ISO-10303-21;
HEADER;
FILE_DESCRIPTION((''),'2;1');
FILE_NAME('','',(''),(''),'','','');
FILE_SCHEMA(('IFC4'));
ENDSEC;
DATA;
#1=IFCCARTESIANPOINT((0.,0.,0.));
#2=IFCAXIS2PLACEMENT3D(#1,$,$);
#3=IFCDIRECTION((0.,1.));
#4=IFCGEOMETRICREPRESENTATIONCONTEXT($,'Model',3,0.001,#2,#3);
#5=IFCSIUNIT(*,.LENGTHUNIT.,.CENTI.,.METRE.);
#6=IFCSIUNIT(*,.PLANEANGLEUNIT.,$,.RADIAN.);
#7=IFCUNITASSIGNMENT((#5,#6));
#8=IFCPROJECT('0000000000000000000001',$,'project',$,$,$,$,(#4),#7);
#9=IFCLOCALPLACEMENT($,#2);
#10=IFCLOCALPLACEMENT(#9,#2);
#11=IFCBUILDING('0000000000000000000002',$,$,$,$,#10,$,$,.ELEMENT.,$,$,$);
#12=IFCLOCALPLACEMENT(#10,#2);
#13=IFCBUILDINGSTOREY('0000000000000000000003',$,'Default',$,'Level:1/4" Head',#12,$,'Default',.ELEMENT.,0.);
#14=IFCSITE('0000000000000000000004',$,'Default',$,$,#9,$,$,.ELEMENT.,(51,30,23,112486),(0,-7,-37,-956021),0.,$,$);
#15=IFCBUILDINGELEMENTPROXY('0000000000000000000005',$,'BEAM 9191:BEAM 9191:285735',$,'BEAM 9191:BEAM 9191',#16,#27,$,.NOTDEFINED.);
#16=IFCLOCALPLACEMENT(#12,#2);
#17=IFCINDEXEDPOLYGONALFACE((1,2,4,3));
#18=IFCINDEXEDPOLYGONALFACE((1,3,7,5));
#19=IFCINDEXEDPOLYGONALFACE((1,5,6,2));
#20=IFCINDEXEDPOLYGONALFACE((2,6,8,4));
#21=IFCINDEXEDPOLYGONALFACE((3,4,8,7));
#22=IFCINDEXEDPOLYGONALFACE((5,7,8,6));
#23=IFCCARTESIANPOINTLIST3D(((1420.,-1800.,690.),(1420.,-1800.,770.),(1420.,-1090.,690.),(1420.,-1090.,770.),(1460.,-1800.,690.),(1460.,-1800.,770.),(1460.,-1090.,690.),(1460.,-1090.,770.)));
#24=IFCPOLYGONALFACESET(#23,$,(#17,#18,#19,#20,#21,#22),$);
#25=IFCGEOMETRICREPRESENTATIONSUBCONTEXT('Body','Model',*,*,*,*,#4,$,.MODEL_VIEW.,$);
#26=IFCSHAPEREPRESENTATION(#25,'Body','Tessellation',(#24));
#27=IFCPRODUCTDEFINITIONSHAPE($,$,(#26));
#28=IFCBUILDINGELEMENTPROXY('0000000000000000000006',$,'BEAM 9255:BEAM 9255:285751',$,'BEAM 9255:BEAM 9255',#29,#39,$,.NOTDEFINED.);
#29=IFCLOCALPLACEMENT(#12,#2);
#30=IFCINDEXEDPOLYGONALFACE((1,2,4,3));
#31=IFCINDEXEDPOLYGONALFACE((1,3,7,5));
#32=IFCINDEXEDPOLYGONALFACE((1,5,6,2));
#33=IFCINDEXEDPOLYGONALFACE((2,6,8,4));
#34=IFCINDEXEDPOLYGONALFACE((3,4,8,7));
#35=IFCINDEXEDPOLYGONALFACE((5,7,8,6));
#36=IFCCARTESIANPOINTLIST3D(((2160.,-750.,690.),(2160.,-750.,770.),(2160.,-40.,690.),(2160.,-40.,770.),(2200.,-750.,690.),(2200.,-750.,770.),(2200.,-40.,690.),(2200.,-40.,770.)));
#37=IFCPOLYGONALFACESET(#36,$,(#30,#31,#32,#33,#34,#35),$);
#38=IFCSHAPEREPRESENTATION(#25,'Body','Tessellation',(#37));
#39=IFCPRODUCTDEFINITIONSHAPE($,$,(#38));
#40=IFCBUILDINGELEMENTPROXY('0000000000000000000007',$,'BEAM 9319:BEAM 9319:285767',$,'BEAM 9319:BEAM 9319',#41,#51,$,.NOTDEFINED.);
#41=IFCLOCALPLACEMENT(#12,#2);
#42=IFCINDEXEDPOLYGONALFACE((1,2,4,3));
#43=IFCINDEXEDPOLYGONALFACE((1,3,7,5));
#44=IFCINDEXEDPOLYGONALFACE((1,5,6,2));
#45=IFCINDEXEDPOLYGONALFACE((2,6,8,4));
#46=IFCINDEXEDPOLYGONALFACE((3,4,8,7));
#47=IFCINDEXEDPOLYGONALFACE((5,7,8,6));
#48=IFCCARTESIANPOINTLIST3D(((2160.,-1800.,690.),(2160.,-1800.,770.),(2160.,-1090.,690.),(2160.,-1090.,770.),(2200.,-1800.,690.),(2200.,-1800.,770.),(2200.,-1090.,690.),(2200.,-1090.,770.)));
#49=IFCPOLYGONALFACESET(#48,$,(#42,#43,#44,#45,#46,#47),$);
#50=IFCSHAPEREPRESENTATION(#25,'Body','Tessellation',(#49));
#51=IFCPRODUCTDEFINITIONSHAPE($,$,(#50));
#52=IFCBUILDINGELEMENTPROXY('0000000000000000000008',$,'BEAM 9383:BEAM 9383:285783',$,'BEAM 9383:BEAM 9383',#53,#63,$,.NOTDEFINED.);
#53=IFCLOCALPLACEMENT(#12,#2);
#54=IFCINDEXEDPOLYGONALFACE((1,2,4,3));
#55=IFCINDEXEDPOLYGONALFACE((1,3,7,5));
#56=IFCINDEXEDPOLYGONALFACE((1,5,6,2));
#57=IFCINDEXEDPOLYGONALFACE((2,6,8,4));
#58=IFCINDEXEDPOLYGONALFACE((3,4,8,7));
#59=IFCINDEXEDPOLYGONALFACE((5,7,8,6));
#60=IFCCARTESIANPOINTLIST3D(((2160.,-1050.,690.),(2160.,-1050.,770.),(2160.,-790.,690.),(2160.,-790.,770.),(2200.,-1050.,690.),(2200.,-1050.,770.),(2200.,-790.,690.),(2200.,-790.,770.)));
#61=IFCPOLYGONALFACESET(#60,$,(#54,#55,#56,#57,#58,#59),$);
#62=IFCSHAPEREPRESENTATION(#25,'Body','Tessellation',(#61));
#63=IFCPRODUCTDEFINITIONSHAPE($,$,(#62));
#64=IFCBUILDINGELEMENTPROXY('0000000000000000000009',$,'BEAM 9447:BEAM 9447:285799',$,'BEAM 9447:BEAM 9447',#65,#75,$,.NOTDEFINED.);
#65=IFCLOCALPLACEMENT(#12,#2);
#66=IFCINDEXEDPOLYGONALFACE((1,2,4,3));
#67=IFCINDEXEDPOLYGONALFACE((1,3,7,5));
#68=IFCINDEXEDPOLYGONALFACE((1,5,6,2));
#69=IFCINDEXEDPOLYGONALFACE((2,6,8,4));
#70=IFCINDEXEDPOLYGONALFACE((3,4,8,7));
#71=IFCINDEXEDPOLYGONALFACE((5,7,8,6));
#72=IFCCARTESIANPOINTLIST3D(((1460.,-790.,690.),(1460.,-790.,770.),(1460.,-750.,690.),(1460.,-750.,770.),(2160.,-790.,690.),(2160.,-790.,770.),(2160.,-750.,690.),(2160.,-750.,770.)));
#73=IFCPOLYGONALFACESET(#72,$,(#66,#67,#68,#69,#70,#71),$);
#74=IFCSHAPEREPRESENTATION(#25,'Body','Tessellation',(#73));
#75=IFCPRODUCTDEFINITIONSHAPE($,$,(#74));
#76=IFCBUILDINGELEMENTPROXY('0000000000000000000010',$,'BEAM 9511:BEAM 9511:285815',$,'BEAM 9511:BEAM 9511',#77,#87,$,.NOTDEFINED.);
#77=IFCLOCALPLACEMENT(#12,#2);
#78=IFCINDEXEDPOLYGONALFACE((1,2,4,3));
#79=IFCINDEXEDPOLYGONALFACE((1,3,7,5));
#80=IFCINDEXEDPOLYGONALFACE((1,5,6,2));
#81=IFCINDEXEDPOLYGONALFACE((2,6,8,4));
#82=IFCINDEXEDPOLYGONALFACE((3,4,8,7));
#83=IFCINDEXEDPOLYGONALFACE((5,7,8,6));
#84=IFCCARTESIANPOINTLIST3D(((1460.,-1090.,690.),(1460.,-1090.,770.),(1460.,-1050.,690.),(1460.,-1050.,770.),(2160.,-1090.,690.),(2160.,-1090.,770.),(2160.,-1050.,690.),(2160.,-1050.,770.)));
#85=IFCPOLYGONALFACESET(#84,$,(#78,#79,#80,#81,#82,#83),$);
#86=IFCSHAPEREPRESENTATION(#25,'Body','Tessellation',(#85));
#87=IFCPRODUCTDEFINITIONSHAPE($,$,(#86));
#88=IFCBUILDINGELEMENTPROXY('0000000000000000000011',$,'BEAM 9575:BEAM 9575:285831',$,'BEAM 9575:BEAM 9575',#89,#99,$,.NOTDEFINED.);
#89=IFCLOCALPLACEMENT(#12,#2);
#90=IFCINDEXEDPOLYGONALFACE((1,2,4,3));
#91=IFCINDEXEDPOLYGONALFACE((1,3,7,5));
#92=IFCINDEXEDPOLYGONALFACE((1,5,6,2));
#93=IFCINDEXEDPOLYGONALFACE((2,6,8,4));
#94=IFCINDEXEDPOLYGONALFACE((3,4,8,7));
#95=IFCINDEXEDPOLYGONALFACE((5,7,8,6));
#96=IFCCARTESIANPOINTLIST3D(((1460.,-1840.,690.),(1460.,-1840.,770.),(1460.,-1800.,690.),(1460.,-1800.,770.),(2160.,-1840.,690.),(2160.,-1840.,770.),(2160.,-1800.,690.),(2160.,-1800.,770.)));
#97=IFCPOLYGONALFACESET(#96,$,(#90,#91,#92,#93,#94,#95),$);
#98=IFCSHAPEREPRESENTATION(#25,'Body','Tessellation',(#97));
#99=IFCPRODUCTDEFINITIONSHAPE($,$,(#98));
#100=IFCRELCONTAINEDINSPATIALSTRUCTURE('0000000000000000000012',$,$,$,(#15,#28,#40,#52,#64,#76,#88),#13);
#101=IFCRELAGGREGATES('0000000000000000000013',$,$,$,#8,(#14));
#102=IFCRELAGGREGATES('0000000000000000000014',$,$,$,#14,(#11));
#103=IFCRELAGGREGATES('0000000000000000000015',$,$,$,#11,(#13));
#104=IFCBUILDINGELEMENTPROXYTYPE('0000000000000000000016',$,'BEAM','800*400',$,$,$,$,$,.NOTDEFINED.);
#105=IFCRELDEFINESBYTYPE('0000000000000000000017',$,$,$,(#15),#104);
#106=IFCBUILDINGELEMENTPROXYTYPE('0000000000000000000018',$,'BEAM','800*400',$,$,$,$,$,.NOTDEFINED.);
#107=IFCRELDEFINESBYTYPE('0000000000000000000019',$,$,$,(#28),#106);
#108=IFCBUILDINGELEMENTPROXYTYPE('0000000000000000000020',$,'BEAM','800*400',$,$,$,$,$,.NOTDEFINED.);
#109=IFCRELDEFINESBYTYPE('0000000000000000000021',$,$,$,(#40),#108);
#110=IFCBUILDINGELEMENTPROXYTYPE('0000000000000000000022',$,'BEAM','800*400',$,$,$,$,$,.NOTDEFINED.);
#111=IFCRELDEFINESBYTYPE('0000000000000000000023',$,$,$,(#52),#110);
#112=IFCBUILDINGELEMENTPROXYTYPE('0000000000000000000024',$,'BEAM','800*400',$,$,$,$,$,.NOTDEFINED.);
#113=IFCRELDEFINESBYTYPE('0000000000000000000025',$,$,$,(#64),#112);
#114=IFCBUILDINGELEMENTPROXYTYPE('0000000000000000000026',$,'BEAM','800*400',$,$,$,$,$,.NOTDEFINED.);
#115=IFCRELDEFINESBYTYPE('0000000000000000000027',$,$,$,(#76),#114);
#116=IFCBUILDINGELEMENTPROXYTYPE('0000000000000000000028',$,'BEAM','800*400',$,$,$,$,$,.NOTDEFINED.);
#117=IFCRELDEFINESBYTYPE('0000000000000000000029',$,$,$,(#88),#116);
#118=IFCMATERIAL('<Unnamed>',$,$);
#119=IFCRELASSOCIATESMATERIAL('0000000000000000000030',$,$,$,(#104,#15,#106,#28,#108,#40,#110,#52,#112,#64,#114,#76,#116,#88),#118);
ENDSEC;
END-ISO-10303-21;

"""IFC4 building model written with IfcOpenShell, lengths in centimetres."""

from ifc_helpers import new_model, si_unit, direction, frame, frame_2d, origin, origin_2d_with_axis, place, context, subcontext, project, spatial, rectangle, extrude, source, transform, mapped, material, type_object, type_shapes, element, save


model = new_model("IFC4")

# Units and contexts
model_context = context("Model", 3, precision=0.001, world=origin(), true_north=direction((0.0, 1.0)))
body_context = subcontext(model_context, "Body", "Model", "MODEL_VIEW")
ifc_project = project(units=[si_unit("LENGTHUNIT", "METRE", prefix="CENTI"), si_unit("PLANEANGLEUNIT", "RADIAN")], contexts=[model_context])

# Site, building, storey
site_placement = place(None, origin())
site = spatial("IfcSite", under=ifc_project, at=site_placement, Name="Default", CompositionType="ELEMENT", RefLatitude=(51, 30, 23, 112486), RefLongitude=(0, -7, -37, -956021), RefElevation=0.0)
building_placement = place(site_placement, origin())
building = spatial("IfcBuilding", under=site, at=building_placement, CompositionType="ELEMENT")
storey_placement = place(building_placement, origin())
storey = spatial("IfcBuildingStorey", under=building, at=storey_placement, Name="Default", ObjectType="Level:1/4\" Head", LongName="Default", CompositionType="ELEMENT", Elevation=0.0)

# Building element proxies
ifc_material_1 = material(Name="<Unnamed>")
building_element_proxy_type_1 = type_object("IfcBuildingElementProxyType", Name="BEAM", Description="800*400", PredefinedType="NOTDEFINED", material=ifc_material_1)
shared_shape_1 = source(origin(), body_context, "Body", "SweptSolid", [
    extrude(rectangle(XDim=40.0, YDim=710.0, at=frame_2d((0.0, 0.0), x_axis=(1.0, 0.0))), frame((20.0, 355.0, 0.0)), (0.0, 0.0, 1.0), 80.0),
])
type_shapes(building_element_proxy_type_1, [shared_shape_1])
proxy_1_placement = place(storey_placement, frame((1420.0, -1800.0, 690.0)))
element("IfcBuildingElementProxy", 1, at=proxy_1_placement, inside=storey, type_object=building_element_proxy_type_1, material=ifc_material_1, Name="BEAM 9191:BEAM 9191:285735", ObjectType="BEAM 9191:BEAM 9191", PredefinedType="NOTDEFINED", context=body_context, shape_type="MappedRepresentation", body=[
    mapped(shared_shape_1, transform((0.0, 0.0, 0.0), scale=1.0)),
])
building_element_proxy_type_2 = type_object("IfcBuildingElementProxyType", Name="BEAM", Description="800*400", PredefinedType="NOTDEFINED", material=ifc_material_1)
shared_shape_2 = source(origin(), body_context, "Body", "SweptSolid", [
    extrude(rectangle(XDim=40.0, YDim=710.0, at=frame_2d((0.0, 0.0), x_axis=(1.0, 0.0))), frame((20.0, 355.0, 0.0)), (0.0, 0.0, 1.0), 80.0),
])
type_shapes(building_element_proxy_type_2, [shared_shape_2])
proxy_2_placement = place(storey_placement, frame((2160.0, -750.0, 690.0)))
element("IfcBuildingElementProxy", 2, at=proxy_2_placement, inside=storey, type_object=building_element_proxy_type_2, material=ifc_material_1, Name="BEAM 9255:BEAM 9255:285751", ObjectType="BEAM 9255:BEAM 9255", PredefinedType="NOTDEFINED", context=body_context, shape_type="MappedRepresentation", body=[
    mapped(shared_shape_2, transform((0.0, 0.0, 0.0), scale=1.0)),
])
building_element_proxy_type_3 = type_object("IfcBuildingElementProxyType", Name="BEAM", Description="800*400", PredefinedType="NOTDEFINED", material=ifc_material_1)
shared_shape_3 = source(origin(), body_context, "Body", "SweptSolid", [
    extrude(rectangle(XDim=40.0, YDim=710.0, at=frame_2d((0.0, 0.0), x_axis=(1.0, 0.0))), frame((20.0, 355.0, 0.0)), (0.0, 0.0, 1.0), 80.0),
])
type_shapes(building_element_proxy_type_3, [shared_shape_3])
proxy_3_placement = place(storey_placement, frame((2160.0, -1800.0, 690.0)))
element("IfcBuildingElementProxy", 3, at=proxy_3_placement, inside=storey, type_object=building_element_proxy_type_3, material=ifc_material_1, Name="BEAM 9319:BEAM 9319:285767", ObjectType="BEAM 9319:BEAM 9319", PredefinedType="NOTDEFINED", context=body_context, shape_type="MappedRepresentation", body=[
    mapped(shared_shape_3, transform((0.0, 0.0, 0.0), scale=1.0)),
])
building_element_proxy_type_4 = type_object("IfcBuildingElementProxyType", Name="BEAM", Description="800*400", PredefinedType="NOTDEFINED", material=ifc_material_1)
shared_shape_4 = source(origin(), body_context, "Body", "SweptSolid", [
    extrude(rectangle(XDim=40.0, YDim=260.0, at=frame_2d((0.0, 0.0), x_axis=(1.0, 0.0))), frame((20.0, 130.0, 0.0)), (0.0, 0.0, 1.0), 80.0),
])
type_shapes(building_element_proxy_type_4, [shared_shape_4])
proxy_4_placement = place(storey_placement, frame((2160.0, -1050.0, 690.0)))
element("IfcBuildingElementProxy", 4, at=proxy_4_placement, inside=storey, type_object=building_element_proxy_type_4, material=ifc_material_1, Name="BEAM 9383:BEAM 9383:285783", ObjectType="BEAM 9383:BEAM 9383", PredefinedType="NOTDEFINED", context=body_context, shape_type="MappedRepresentation", body=[
    mapped(shared_shape_4, transform((0.0, 0.0, 0.0), scale=1.0)),
])
building_element_proxy_type_5 = type_object("IfcBuildingElementProxyType", Name="BEAM", Description="800*400", PredefinedType="NOTDEFINED", material=ifc_material_1)
shared_shape_5 = source(origin(), body_context, "Body", "SweptSolid", [
    extrude(rectangle(XDim=40.0, YDim=700.0, at=origin_2d_with_axis()), frame((350.0, 20.0, 0.0), z_axis=(0.0, 0.0, 1.0), x_axis=(0.0, 1.0, 0.0)), (0.0, 0.0, 1.0), 80.0),
])
type_shapes(building_element_proxy_type_5, [shared_shape_5])
proxy_5_placement = place(storey_placement, frame((1460.0, -790.0, 690.0)))
element("IfcBuildingElementProxy", 5, at=proxy_5_placement, inside=storey, type_object=building_element_proxy_type_5, material=ifc_material_1, Name="BEAM 9447:BEAM 9447:285799", ObjectType="BEAM 9447:BEAM 9447", PredefinedType="NOTDEFINED", context=body_context, shape_type="MappedRepresentation", body=[
    mapped(shared_shape_5, transform((0.0, 0.0, 0.0), scale=1.0)),
])
building_element_proxy_type_6 = type_object("IfcBuildingElementProxyType", Name="BEAM", Description="800*400", PredefinedType="NOTDEFINED", material=ifc_material_1)
shared_shape_6 = source(origin(), body_context, "Body", "SweptSolid", [
    extrude(rectangle(XDim=40.0, YDim=700.0, at=origin_2d_with_axis()), frame((350.0, 20.0, 0.0), z_axis=(0.0, 0.0, 1.0), x_axis=(0.0, 1.0, 0.0)), (0.0, 0.0, 1.0), 80.0),
])
type_shapes(building_element_proxy_type_6, [shared_shape_6])
proxy_6_placement = place(storey_placement, frame((1460.0, -1090.0, 690.0)))
element("IfcBuildingElementProxy", 6, at=proxy_6_placement, inside=storey, type_object=building_element_proxy_type_6, material=ifc_material_1, Name="BEAM 9511:BEAM 9511:285815", ObjectType="BEAM 9511:BEAM 9511", PredefinedType="NOTDEFINED", context=body_context, shape_type="MappedRepresentation", body=[
    mapped(shared_shape_6, transform((0.0, 0.0, 0.0), scale=1.0)),
])
building_element_proxy_type_7 = type_object("IfcBuildingElementProxyType", Name="BEAM", Description="800*400", PredefinedType="NOTDEFINED", material=ifc_material_1)
shared_shape_7 = source(origin(), body_context, "Body", "SweptSolid", [
    extrude(rectangle(XDim=40.0, YDim=700.0, at=origin_2d_with_axis()), frame((350.0, 20.0, 0.0), z_axis=(0.0, 0.0, 1.0), x_axis=(0.0, 1.0, 0.0)), (0.0, 0.0, 1.0), 80.0),
])
type_shapes(building_element_proxy_type_7, [shared_shape_7])
proxy_7_placement = place(storey_placement, frame((1460.0, -1840.0, 690.0)))
element("IfcBuildingElementProxy", 7, at=proxy_7_placement, inside=storey, type_object=building_element_proxy_type_7, material=ifc_material_1, Name="BEAM 9575:BEAM 9575:285831", ObjectType="BEAM 9575:BEAM 9575", PredefinedType="NOTDEFINED", context=body_context, shape_type="MappedRepresentation", body=[
    mapped(shared_shape_7, transform((0.0, 0.0, 0.0), scale=1.0)),
])

save(model, "model.ifc")
